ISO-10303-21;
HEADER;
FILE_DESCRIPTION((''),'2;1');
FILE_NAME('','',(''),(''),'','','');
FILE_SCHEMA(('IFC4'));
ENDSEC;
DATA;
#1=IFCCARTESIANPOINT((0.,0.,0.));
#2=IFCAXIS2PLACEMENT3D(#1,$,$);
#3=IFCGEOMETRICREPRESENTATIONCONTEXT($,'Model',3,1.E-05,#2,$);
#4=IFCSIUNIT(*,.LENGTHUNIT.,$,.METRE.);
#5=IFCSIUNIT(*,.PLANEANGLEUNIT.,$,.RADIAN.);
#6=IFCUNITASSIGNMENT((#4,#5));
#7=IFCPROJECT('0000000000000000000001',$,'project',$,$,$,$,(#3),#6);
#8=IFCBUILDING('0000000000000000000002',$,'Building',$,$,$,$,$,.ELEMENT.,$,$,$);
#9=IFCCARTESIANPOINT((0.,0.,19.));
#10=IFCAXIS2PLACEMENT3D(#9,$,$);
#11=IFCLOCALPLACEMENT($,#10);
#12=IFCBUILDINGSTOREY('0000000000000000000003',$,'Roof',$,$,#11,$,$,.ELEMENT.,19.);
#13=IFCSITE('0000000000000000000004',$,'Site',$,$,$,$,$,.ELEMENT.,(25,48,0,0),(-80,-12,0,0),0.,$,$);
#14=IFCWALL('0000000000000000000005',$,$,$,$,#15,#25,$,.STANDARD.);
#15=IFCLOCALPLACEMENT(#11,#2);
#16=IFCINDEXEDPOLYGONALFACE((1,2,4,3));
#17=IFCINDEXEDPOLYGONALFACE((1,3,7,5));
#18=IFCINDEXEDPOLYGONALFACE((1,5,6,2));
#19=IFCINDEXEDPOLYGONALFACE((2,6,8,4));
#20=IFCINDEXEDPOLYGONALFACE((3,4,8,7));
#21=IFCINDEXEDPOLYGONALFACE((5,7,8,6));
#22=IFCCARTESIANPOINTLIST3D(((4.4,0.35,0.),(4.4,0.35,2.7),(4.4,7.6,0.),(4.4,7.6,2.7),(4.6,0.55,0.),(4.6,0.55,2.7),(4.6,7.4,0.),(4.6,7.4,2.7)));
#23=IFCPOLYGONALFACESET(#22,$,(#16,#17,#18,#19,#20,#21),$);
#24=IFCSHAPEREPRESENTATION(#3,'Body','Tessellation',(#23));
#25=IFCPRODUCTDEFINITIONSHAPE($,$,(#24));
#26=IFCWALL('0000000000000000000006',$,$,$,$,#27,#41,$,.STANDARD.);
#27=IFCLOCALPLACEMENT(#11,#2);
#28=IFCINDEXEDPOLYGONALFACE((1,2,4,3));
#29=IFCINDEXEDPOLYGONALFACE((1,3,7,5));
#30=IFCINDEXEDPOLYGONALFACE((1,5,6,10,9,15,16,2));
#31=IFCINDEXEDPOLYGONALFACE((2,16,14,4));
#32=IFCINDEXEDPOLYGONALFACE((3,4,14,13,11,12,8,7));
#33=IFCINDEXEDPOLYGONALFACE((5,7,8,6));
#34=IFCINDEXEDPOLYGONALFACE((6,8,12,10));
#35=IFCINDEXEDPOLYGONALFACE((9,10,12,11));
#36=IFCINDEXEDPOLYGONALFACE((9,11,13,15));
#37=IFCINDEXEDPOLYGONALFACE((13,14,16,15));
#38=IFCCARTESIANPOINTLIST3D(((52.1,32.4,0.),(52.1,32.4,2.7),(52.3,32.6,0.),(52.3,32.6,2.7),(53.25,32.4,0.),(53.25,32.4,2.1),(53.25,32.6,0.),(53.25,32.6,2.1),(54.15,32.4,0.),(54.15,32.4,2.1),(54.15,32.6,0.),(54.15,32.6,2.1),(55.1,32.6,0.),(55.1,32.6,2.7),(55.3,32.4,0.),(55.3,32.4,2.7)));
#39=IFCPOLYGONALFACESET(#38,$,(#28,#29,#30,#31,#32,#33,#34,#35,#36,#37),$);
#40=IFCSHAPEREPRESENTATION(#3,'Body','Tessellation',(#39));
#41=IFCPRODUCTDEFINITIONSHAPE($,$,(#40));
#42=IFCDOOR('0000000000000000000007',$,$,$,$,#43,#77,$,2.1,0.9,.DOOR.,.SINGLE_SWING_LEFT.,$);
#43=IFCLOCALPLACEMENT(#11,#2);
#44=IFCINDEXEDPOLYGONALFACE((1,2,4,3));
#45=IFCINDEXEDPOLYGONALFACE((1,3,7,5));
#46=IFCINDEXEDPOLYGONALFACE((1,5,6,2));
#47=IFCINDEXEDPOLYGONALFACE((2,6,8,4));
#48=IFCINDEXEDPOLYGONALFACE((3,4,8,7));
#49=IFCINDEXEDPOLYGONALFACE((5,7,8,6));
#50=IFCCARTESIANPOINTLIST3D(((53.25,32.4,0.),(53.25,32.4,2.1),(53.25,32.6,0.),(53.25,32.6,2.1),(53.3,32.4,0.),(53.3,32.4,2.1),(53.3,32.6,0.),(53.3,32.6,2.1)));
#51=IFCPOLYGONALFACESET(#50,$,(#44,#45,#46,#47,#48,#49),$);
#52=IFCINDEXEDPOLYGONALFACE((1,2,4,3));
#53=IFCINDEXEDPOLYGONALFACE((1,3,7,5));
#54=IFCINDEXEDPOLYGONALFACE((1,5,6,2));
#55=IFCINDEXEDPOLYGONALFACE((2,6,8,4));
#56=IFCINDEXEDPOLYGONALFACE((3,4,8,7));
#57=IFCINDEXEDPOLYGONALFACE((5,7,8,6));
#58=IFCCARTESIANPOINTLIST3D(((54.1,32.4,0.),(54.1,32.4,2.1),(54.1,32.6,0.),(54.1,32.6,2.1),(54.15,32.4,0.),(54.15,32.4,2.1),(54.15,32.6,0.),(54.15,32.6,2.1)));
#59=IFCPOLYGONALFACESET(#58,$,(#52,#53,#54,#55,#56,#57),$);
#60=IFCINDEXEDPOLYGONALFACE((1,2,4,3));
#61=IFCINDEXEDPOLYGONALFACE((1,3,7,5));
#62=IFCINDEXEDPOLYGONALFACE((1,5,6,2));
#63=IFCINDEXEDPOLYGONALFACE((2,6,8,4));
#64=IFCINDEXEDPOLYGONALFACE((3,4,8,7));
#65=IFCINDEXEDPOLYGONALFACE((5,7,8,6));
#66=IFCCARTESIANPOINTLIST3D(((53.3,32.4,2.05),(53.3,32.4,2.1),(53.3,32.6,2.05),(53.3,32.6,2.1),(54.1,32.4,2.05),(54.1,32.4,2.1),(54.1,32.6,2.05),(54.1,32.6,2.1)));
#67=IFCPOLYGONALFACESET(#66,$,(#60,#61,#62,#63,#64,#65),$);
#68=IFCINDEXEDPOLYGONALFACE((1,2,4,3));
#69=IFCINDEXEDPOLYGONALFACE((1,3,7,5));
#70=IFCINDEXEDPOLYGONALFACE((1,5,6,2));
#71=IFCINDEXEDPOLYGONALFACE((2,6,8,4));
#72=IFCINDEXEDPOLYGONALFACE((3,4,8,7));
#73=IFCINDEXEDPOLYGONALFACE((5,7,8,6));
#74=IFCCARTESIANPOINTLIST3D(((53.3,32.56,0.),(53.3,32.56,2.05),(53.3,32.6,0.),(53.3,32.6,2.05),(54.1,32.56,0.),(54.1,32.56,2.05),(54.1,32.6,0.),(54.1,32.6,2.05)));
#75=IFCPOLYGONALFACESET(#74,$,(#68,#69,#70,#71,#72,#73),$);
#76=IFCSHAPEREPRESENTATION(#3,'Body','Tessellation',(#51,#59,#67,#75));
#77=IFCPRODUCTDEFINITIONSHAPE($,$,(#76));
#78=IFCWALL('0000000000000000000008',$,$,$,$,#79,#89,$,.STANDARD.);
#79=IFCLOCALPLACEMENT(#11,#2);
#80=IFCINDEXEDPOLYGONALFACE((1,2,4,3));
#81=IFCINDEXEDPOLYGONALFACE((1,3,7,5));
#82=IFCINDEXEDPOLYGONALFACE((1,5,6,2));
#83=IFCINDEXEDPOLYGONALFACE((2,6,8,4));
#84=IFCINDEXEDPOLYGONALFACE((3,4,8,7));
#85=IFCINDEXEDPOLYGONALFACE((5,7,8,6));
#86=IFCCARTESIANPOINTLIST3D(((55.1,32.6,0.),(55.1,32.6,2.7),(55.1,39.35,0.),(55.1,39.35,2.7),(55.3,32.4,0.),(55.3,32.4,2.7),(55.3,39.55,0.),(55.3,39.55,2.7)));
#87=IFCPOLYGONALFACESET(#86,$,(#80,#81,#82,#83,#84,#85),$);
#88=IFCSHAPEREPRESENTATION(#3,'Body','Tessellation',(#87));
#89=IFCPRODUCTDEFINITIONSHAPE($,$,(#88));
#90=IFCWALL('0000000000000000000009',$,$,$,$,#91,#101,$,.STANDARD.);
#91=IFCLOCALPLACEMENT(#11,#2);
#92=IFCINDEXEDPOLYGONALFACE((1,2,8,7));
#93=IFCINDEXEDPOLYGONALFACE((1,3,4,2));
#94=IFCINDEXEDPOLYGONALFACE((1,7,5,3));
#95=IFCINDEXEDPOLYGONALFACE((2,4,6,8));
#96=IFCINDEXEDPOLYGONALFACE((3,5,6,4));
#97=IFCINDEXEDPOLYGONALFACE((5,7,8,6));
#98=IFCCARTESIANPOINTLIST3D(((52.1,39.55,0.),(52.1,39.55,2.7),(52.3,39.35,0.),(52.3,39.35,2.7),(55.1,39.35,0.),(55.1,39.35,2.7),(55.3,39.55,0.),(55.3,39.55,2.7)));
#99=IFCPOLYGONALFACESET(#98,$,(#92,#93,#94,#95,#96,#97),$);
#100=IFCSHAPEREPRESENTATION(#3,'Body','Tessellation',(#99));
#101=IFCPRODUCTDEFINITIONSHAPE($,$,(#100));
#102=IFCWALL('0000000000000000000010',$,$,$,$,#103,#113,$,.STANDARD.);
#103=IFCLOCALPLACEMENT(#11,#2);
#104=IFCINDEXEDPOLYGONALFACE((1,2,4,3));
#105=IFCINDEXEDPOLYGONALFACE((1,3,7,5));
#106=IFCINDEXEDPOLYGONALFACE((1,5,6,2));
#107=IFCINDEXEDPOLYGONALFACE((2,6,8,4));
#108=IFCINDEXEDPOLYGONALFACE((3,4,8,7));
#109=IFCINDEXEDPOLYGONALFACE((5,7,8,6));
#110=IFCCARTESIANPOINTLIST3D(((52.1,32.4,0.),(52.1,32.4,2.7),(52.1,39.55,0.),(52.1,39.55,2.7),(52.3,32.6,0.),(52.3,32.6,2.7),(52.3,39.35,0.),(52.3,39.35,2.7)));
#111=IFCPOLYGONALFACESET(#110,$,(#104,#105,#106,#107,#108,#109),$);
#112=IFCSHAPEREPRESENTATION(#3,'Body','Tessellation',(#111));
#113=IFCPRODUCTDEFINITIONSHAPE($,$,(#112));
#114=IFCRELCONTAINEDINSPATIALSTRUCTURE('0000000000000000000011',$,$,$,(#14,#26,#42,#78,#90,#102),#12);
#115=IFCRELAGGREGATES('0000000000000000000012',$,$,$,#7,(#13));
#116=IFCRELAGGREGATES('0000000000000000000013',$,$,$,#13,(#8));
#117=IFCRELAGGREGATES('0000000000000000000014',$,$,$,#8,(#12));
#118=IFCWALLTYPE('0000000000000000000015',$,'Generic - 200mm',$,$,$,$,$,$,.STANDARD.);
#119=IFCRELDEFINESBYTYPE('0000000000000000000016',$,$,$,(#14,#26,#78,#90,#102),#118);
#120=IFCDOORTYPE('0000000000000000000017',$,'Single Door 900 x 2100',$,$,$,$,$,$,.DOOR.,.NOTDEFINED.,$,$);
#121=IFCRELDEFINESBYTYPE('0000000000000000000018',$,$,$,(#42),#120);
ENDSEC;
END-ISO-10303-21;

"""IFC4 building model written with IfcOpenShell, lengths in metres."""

from ifc_helpers import new_model, si_unit, frame, frame_2d, origin, origin_with_axes, origin_2d, place, context, project, spatial, polyline, rectangle, outline, extrude, type_object, element, fill, save


model = new_model("IFC4")

# Units and contexts
model_context = context("Model", 3, precision=1e-05, world=origin())
ifc_project = project(units=[si_unit("LENGTHUNIT", "METRE"), si_unit("PLANEANGLEUNIT", "RADIAN")], contexts=[model_context])

# Site, building, storey
site = spatial("IfcSite", under=ifc_project, Name="Site", CompositionType="ELEMENT", RefLatitude=(25, 48, 0, 0), RefLongitude=(-80, -12, 0, 0), RefElevation=0.0)
building = spatial("IfcBuilding", under=site, Name="Building", CompositionType="ELEMENT")
storey_placement = place(None, frame((0.0, 0.0, 19.0)))
storey = spatial("IfcBuildingStorey", under=building, at=storey_placement, Name="Roof", CompositionType="ELEMENT", Elevation=19.0)

# Shared definitions
wall_type = type_object("IfcWallType", Name="Generic - 200mm", PredefinedType="STANDARD")
door_type = type_object("IfcDoorType", Name="Single Door 900 x 2100", OperationType="NOTDEFINED", PredefinedType="DOOR")

# Wall
wall_1_placement = place(None, frame((4.5, 0.45, 19.0), z_axis=(0.0, 0.0, 1.0), x_axis=(0.0, 1.0, 0.0)))
element("IfcWall", 1, at=wall_1_placement, inside=storey, type_object=wall_type, PredefinedType="STANDARD", context=model_context, shape_type="SweptSolid", body=[
    extrude(outline(polyline([(0.1, -0.1), (6.95, -0.1), (7.15, 0.1), (-0.1, 0.1), (0.1, -0.1)])), origin(), (0.0, 0.0, 1.0), 2.7),
])

# Wall, opening, door
wall_2_placement = place(None, frame((52.2, 32.5, 19.0), z_axis=(0.0, 0.0, 1.0), x_axis=(1.0, 0.0, 0.0)))
wall_2 = element("IfcWall", 2, at=wall_2_placement, inside=storey, type_object=wall_type, PredefinedType="STANDARD", context=model_context, shape_type="SweptSolid", body=[
    extrude(outline(polyline([(-0.1, -0.1), (3.1, -0.1), (2.9, 0.1), (0.1, 0.1), (-0.1, -0.1)])), origin(), (0.0, 0.0, 1.0), 2.7),
])
opening_1_placement = place(wall_2_placement, frame((1.5, 0.0, 0.0), z_axis=(0.0, 0.0, 1.0), x_axis=(1.0, 0.0, 0.0)))
opening_1 = element("IfcOpeningElement", 3, at=opening_1_placement, cuts=wall_2, PredefinedType="OPENING", context=model_context, shape_type="SweptSolid", body=[
    extrude(rectangle(XDim=0.9, YDim=0.202, at=origin_2d()), origin(), (0.0, 0.0, 1.0), 2.1),
])
door_1_placement = place(opening_1_placement, origin_with_axes())
door_1 = element("IfcDoor", 4, at=door_1_placement, inside=storey, type_object=door_type, OperationType="SINGLE_SWING_LEFT", OverallHeight=2.1, OverallWidth=0.9, PredefinedType="DOOR", context=model_context, shape_type="SweptSolid", body=[
    extrude(rectangle(XDim=0.05, YDim=0.2, at=frame_2d((-0.425, 0.0))), origin(), (0.0, 0.0, 1.0), 2.1),
    extrude(rectangle(XDim=0.05, YDim=0.2, at=frame_2d((0.425, 0.0))), origin(), (0.0, 0.0, 1.0), 2.1),
    extrude(rectangle(XDim=0.8, YDim=0.2, at=origin_2d()), frame((0.0, 0.0, 2.05)), (0.0, 0.0, 1.0), 0.05),
    extrude(rectangle(XDim=0.8, YDim=0.04, at=frame_2d((0.0, 0.08))), origin(), (0.0, 0.0, 1.0), 2.05),
])
fill(opening_1, door_1)

# Walls
wall_3_placement = place(None, frame((55.2, 32.5, 19.0), z_axis=(0.0, 0.0, 1.0), x_axis=(0.0, 1.0, 0.0)))
element("IfcWall", 5, at=wall_3_placement, inside=storey, type_object=wall_type, PredefinedType="STANDARD", context=model_context, shape_type="SweptSolid", body=[
    extrude(outline(polyline([(-0.1, -0.1), (7.05, -0.1), (6.85, 0.1), (0.1, 0.1), (-0.1, -0.1)])), origin(), (0.0, 0.0, 1.0), 2.7),
])
wall_4_placement = place(None, frame((55.2, 39.45, 19.0), z_axis=(0.0, 0.0, 1.0), x_axis=(-1.0, 0.0, 0.0)))
element("IfcWall", 6, at=wall_4_placement, inside=storey, type_object=wall_type, PredefinedType="STANDARD", context=model_context, shape_type="SweptSolid", body=[
    extrude(outline(polyline([(-0.1, -0.1), (3.1, -0.1), (2.9, 0.1), (0.1, 0.1), (-0.1, -0.1)])), origin(), (0.0, 0.0, 1.0), 2.7),
])
wall_5_placement = place(None, frame((52.2, 39.45, 19.0), z_axis=(0.0, 0.0, 1.0), x_axis=(0.0, -1.0, 0.0)))
element("IfcWall", 7, at=wall_5_placement, inside=storey, type_object=wall_type, PredefinedType="STANDARD", context=model_context, shape_type="SweptSolid", body=[
    extrude(outline(polyline([(-0.1, -0.1), (7.05, -0.1), (6.85, 0.1), (0.1, 0.1), (-0.1, -0.1)])), origin(), (0.0, 0.0, 1.0), 2.7),
])

save(model, "model.ifc")
